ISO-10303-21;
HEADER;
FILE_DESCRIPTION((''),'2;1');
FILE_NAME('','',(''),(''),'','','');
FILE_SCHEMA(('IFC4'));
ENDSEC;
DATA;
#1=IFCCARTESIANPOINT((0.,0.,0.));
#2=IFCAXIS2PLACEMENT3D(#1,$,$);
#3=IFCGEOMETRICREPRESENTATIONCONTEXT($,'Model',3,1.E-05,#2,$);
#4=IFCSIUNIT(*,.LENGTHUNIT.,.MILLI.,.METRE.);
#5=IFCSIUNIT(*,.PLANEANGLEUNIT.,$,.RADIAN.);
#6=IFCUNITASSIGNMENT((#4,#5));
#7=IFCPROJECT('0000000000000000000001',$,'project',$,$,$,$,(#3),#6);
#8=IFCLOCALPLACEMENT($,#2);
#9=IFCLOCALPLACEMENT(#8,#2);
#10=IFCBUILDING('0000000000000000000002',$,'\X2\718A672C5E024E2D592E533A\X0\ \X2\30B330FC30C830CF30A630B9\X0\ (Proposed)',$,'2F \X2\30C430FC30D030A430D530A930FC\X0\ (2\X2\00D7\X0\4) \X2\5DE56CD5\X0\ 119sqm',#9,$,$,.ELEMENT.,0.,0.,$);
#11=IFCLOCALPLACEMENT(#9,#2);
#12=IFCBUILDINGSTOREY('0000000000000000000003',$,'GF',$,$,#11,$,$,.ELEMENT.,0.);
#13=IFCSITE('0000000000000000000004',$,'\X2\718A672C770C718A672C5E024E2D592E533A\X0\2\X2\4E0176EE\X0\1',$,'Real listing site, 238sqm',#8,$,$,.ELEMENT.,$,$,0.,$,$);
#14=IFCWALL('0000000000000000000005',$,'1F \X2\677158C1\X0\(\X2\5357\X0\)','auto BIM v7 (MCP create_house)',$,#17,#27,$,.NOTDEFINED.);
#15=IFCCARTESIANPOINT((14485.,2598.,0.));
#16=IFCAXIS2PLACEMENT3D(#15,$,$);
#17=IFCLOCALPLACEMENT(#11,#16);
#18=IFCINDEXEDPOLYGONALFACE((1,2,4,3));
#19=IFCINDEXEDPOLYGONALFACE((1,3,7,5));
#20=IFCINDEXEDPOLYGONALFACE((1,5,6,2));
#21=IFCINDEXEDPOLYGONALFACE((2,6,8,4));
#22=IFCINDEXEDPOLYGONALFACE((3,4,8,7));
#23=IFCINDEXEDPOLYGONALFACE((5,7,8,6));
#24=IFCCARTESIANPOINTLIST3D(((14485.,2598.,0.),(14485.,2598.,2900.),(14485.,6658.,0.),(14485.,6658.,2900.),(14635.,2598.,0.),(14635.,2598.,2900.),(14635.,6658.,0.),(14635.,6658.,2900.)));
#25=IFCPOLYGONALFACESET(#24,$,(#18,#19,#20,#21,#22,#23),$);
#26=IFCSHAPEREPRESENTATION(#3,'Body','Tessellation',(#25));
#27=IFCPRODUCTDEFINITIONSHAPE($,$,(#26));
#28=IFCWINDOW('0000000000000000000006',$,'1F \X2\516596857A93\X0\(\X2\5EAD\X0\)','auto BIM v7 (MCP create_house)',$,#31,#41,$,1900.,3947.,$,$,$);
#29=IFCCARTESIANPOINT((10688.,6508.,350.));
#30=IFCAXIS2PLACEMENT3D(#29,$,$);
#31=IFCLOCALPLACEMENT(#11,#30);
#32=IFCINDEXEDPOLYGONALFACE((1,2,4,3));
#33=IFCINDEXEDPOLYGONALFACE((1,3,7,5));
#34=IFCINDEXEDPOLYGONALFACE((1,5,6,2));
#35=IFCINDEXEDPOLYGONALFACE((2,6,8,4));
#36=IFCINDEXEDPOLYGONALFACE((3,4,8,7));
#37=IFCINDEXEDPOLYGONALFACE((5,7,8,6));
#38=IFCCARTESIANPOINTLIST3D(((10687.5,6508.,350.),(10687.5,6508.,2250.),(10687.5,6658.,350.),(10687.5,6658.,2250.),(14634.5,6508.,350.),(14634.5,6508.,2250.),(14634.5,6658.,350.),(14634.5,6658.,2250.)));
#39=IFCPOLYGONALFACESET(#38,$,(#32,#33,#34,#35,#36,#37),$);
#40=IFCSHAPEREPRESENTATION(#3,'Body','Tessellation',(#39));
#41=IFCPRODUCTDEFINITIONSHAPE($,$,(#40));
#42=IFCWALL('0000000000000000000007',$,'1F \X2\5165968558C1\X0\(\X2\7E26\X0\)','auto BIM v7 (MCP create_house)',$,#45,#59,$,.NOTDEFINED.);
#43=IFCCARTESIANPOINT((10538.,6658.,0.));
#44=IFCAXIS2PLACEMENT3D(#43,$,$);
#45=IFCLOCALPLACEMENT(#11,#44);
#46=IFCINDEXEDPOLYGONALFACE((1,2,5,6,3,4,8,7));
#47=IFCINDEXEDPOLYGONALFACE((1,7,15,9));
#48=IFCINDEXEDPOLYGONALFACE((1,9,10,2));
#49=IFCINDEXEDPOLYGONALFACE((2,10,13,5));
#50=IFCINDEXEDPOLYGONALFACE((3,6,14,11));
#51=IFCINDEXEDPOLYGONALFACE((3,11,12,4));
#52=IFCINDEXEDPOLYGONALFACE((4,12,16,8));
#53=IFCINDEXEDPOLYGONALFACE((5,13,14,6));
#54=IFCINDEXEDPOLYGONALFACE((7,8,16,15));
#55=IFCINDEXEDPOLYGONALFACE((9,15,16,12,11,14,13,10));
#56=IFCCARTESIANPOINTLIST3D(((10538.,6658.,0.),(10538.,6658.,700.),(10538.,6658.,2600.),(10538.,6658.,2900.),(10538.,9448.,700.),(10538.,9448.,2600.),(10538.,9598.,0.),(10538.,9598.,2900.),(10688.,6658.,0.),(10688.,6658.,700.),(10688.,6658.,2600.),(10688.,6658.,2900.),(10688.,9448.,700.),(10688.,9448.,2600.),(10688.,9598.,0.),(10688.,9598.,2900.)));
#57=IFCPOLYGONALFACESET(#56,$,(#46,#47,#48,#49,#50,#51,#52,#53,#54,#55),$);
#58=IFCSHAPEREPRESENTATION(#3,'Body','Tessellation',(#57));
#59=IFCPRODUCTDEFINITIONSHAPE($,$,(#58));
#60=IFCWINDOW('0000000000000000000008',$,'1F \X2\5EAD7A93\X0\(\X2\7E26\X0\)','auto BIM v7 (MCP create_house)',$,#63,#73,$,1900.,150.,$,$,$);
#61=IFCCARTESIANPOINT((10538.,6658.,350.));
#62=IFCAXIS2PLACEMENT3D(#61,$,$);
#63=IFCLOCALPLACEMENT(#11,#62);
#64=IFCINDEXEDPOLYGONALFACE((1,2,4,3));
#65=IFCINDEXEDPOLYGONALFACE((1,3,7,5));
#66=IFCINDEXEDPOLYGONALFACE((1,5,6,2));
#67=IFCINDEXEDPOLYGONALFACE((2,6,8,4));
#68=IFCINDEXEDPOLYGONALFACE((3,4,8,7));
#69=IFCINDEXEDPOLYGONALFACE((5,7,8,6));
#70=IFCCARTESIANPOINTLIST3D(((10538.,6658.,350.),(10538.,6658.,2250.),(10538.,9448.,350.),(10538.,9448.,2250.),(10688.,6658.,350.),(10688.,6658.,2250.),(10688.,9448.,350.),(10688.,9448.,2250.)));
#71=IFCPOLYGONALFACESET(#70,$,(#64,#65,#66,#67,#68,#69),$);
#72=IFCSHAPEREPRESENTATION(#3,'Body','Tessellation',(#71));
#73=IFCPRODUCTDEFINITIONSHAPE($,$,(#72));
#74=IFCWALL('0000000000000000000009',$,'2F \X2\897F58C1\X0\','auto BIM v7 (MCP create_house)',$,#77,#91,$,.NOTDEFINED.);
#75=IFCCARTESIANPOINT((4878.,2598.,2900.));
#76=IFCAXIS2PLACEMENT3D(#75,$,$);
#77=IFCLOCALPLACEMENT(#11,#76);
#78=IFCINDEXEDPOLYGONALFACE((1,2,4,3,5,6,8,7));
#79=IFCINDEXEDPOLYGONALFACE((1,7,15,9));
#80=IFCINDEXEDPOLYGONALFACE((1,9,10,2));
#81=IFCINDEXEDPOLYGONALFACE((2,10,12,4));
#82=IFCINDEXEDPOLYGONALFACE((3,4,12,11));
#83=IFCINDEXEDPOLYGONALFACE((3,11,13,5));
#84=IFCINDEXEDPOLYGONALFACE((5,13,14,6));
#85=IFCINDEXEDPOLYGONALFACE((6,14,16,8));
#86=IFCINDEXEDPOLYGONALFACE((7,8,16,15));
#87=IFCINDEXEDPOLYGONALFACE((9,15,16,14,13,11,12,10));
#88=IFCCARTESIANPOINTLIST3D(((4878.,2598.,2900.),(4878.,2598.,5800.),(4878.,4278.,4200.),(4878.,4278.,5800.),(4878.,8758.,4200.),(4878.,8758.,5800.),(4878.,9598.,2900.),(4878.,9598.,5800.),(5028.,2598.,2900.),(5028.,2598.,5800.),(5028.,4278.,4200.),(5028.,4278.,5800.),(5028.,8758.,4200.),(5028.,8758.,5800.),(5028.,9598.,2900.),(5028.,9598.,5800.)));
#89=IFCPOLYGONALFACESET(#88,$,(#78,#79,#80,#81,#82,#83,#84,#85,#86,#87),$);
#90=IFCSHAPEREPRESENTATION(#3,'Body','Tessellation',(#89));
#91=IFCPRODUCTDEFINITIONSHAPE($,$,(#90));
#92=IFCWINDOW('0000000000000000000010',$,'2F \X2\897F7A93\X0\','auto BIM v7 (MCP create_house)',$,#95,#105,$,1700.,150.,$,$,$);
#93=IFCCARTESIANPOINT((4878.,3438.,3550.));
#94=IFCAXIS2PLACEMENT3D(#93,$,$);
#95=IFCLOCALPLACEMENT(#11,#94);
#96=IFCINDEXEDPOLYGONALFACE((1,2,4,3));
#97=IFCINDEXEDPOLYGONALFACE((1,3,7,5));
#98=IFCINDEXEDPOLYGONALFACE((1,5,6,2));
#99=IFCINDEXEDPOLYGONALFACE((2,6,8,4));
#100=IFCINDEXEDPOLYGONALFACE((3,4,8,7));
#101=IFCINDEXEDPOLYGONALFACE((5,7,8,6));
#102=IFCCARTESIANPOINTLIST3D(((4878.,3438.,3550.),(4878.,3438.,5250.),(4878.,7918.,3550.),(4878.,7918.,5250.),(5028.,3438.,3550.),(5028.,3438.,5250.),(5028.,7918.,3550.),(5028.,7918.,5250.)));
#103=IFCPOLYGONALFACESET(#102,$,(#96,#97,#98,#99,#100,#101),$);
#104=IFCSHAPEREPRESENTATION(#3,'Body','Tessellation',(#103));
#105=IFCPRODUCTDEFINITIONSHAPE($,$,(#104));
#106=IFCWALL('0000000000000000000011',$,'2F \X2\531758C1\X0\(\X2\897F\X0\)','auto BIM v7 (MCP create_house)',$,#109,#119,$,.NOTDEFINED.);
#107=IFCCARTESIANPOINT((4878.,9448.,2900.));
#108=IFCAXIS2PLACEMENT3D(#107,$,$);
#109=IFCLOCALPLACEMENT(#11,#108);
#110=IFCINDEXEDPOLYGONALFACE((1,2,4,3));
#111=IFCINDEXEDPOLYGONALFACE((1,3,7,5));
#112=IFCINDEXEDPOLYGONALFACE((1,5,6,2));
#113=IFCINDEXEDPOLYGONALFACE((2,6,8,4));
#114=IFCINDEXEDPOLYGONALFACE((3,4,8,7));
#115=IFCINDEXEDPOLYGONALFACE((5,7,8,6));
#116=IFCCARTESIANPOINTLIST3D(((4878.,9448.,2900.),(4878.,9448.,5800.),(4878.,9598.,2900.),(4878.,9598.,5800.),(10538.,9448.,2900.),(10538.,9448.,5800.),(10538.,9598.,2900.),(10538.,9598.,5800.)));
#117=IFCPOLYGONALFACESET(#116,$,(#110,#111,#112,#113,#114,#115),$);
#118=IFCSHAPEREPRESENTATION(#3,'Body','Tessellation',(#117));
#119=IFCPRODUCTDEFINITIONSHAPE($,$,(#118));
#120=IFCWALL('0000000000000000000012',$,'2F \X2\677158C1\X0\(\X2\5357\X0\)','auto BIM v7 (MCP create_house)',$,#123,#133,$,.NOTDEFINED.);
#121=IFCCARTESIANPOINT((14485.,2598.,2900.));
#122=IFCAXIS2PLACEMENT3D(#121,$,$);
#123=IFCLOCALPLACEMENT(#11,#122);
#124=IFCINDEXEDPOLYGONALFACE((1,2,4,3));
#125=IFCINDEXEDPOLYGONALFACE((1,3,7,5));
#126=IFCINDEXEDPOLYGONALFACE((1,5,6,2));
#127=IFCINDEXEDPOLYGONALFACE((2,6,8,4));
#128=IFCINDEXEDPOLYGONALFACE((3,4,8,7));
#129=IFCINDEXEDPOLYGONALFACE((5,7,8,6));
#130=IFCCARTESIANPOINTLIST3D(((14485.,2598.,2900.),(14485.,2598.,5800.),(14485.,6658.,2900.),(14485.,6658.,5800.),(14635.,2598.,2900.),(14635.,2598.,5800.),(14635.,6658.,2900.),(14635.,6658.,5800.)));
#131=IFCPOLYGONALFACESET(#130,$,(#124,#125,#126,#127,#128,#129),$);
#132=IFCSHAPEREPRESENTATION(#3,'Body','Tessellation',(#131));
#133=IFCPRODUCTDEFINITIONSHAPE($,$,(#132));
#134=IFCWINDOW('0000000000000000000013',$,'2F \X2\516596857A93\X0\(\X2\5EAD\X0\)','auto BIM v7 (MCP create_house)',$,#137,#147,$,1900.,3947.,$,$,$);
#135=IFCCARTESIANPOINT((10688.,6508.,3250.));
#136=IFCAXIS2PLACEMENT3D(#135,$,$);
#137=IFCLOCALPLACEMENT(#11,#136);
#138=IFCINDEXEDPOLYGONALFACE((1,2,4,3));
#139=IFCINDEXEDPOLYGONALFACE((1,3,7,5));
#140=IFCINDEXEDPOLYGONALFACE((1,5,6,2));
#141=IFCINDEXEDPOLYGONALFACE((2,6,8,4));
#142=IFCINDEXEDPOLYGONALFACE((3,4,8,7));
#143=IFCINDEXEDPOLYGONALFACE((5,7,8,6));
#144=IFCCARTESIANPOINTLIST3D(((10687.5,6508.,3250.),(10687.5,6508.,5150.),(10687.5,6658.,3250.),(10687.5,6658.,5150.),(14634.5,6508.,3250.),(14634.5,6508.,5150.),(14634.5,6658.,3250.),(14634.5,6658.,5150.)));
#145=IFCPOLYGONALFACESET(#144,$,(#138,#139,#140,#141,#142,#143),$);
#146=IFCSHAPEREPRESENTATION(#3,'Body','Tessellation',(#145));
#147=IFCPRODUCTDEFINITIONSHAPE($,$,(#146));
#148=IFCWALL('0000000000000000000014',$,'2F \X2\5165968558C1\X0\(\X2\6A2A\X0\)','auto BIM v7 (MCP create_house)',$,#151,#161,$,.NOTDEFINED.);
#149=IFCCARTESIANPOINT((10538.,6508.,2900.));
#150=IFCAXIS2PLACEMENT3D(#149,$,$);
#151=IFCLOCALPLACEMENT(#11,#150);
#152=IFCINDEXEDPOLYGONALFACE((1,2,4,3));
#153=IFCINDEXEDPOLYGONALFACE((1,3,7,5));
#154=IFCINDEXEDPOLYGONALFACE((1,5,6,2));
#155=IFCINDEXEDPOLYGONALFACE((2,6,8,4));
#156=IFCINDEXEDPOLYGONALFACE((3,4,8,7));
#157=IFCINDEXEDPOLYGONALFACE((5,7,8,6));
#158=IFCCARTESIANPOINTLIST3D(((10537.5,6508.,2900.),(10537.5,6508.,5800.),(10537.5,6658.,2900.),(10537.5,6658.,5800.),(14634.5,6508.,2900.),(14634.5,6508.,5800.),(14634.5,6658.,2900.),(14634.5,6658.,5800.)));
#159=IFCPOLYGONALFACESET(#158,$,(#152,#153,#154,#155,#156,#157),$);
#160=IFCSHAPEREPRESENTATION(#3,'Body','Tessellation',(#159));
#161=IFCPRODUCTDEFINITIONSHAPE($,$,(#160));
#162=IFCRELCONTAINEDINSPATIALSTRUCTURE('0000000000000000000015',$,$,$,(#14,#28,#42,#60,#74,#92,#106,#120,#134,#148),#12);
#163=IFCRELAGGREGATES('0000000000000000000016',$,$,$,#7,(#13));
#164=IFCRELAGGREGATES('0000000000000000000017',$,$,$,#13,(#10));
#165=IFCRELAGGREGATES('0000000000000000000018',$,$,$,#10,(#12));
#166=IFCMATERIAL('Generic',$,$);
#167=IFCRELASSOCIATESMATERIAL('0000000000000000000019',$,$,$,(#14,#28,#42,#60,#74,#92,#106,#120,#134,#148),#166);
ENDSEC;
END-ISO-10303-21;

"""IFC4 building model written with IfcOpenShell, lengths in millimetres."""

from ifc_helpers import new_model, si_unit, frame, frame_2d, origin, place, context, project, spatial, rectangle, extrude, material, element, fill, save


model = new_model("IFC4")

# Units and contexts
model_context = context("Model", 3, precision=1e-05, world=origin())
ifc_project = project(units=[si_unit("LENGTHUNIT", "METRE", prefix="MILLI"), si_unit("PLANEANGLEUNIT", "RADIAN")], contexts=[model_context])

# Site, building, storey
site_placement = place(None, origin())
site = spatial("IfcSite", under=ifc_project, at=site_placement, Name="熊本県熊本市中央区2丁目1", ObjectType="Real listing site, 238sqm", CompositionType="ELEMENT", RefElevation=0.0)
building_placement = place(site_placement, origin())
building = spatial("IfcBuilding", under=site, at=building_placement, Name="熊本市中央区 コートハウス (Proposed)", ObjectType="2F ツーバイフォー (2×4) 工法 119sqm", CompositionType="ELEMENT", ElevationOfRefHeight=0.0, ElevationOfTerrain=0.0)
storey_placement = place(building_placement, origin())
storey = spatial("IfcBuildingStorey", under=building, at=storey_placement, Name="GF", CompositionType="ELEMENT", Elevation=0.0)

# Shared definitions
ifc_material = material(Name="Generic")

# Wall, opening, window
wall_1_placement = place(storey_placement, frame((14485.0, 2598.0, 0.0)))
wall_1 = element("IfcWall", 1, at=wall_1_placement, inside=storey, material=ifc_material, Name="1F 東壁(南)", Description="auto BIM v7 (MCP create_house)", PredefinedType="NOTDEFINED", context=model_context, shape_type="SweptSolid", body=[
    extrude(rectangle(XDim=150.0, YDim=4060.0, at=frame_2d((75.0, 2030.0))), frame((14485.0, 2598.0, 0.0)), (0.0, 0.0, 1.0), 2900.0),
])
opening_1_placement = place(storey_placement, frame((10688.0, 6508.0, 350.0)))
opening_1 = element("IfcOpeningElement", 2, at=opening_1_placement, cuts=wall_1, PredefinedType="NOTDEFINED", context=model_context, shape_type="SweptSolid", body=[
    extrude(rectangle(XDim=3947.0, YDim=150.0, at=frame_2d((1973.0, 75.0))), frame((10688.0, 6508.0, 350.0)), (0.0, 0.0, 1.0), 1900.0),
])
window_1_placement = place(storey_placement, frame((10688.0, 6508.0, 350.0)))
window_1 = element("IfcWindow", 3, at=window_1_placement, inside=storey, material=ifc_material, Name="1F 入隅窓(庭)", Description="auto BIM v7 (MCP create_house)", OverallHeight=1900.0, OverallWidth=3947.0, context=model_context, shape_type="SweptSolid", body=[
    extrude(rectangle(XDim=3947.0, YDim=150.0, at=frame_2d((1973.0, 75.0))), frame((10688.0, 6508.0, 350.0)), (0.0, 0.0, 1.0), 1900.0),
])
fill(opening_1, window_1)

# Wall, opening, window
wall_2_placement = place(storey_placement, frame((10538.0, 6658.0, 0.0)))
wall_2 = element("IfcWall", 4, at=wall_2_placement, inside=storey, material=ifc_material, Name="1F 入隅壁(縦)", Description="auto BIM v7 (MCP create_house)", PredefinedType="NOTDEFINED", context=model_context, shape_type="SweptSolid", body=[
    extrude(rectangle(XDim=150.0, YDim=2940.0, at=frame_2d((75.0, 1470.0))), frame((10538.0, 6658.0, 0.0)), (0.0, 0.0, 1.0), 2900.0),
])
opening_2_placement = place(storey_placement, frame((10538.0, 6658.0, 350.0)))
opening_2 = element("IfcOpeningElement", 5, at=opening_2_placement, cuts=wall_2, PredefinedType="NOTDEFINED", context=model_context, shape_type="SweptSolid", body=[
    extrude(rectangle(XDim=150.0, YDim=2790.0, at=frame_2d((75.0, 1395.0))), frame((10538.0, 6658.0, 350.0)), (0.0, 0.0, 1.0), 1900.0),
])
window_2_placement = place(storey_placement, frame((10538.0, 6658.0, 350.0)))
window_2 = element("IfcWindow", 6, at=window_2_placement, inside=storey, material=ifc_material, Name="1F 庭窓(縦)", Description="auto BIM v7 (MCP create_house)", OverallHeight=1900.0, OverallWidth=150.0, context=model_context, shape_type="SweptSolid", body=[
    extrude(rectangle(XDim=150.0, YDim=2790.0, at=frame_2d((75.0, 1395.0))), frame((10538.0, 6658.0, 350.0)), (0.0, 0.0, 1.0), 1900.0),
])
fill(opening_2, window_2)

# Wall, opening, window
wall_3_placement = place(storey_placement, frame((4878.0, 2598.0, 2900.0)))
wall_3 = element("IfcWall", 7, at=wall_3_placement, inside=storey, material=ifc_material, Name="2F 西壁", Description="auto BIM v7 (MCP create_house)", PredefinedType="NOTDEFINED", context=model_context, shape_type="SweptSolid", body=[
    extrude(rectangle(XDim=150.0, YDim=7000.0, at=frame_2d((75.0, 3500.0))), frame((4878.0, 2598.0, 2900.0)), (0.0, 0.0, 1.0), 2900.0),
])
opening_3_placement = place(storey_placement, frame((4878.0, 3438.0, 3550.0)))
opening_3 = element("IfcOpeningElement", 8, at=opening_3_placement, cuts=wall_3, PredefinedType="NOTDEFINED", context=model_context, shape_type="SweptSolid", body=[
    extrude(rectangle(XDim=150.0, YDim=4480.0, at=frame_2d((75.0, 2240.0))), frame((4878.0, 3438.0, 3550.0)), (0.0, 0.0, 1.0), 1700.0),
])
window_3_placement = place(storey_placement, frame((4878.0, 3438.0, 3550.0)))
window_3 = element("IfcWindow", 9, at=window_3_placement, inside=storey, material=ifc_material, Name="2F 西窓", Description="auto BIM v7 (MCP create_house)", OverallHeight=1700.0, OverallWidth=150.0, context=model_context, shape_type="SweptSolid", body=[
    extrude(rectangle(XDim=150.0, YDim=4480.0, at=frame_2d((75.0, 2240.0))), frame((4878.0, 3438.0, 3550.0)), (0.0, 0.0, 1.0), 1700.0),
])
fill(opening_3, window_3)

# Wall
wall_4_placement = place(storey_placement, frame((4878.0, 9448.0, 2900.0)))
element("IfcWall", 10, at=wall_4_placement, inside=storey, material=ifc_material, Name="2F 北壁(西)", Description="auto BIM v7 (MCP create_house)", PredefinedType="NOTDEFINED", context=model_context, shape_type="SweptSolid", body=[
    extrude(rectangle(XDim=5660.0, YDim=150.0, at=frame_2d((2830.0, 75.0))), frame((4878.0, 9448.0, 2900.0)), (0.0, 0.0, 1.0), 2900.0),
])

# Wall, opening, window
wall_5_placement = place(storey_placement, frame((14485.0, 2598.0, 2900.0)))
wall_5 = element("IfcWall", 11, at=wall_5_placement, inside=storey, material=ifc_material, Name="2F 東壁(南)", Description="auto BIM v7 (MCP create_house)", PredefinedType="NOTDEFINED", context=model_context, shape_type="SweptSolid", body=[
    extrude(rectangle(XDim=150.0, YDim=4060.0, at=frame_2d((75.0, 2030.0))), frame((14485.0, 2598.0, 2900.0)), (0.0, 0.0, 1.0), 2900.0),
])
opening_4_placement = place(storey_placement, frame((10688.0, 6508.0, 3250.0)))
opening_4 = element("IfcOpeningElement", 12, at=opening_4_placement, cuts=wall_5, PredefinedType="NOTDEFINED", context=model_context, shape_type="SweptSolid", body=[
    extrude(rectangle(XDim=3947.0, YDim=150.0, at=frame_2d((1973.0, 75.0))), frame((10688.0, 6508.0, 3250.0)), (0.0, 0.0, 1.0), 1900.0),
])
window_4_placement = place(storey_placement, frame((10688.0, 6508.0, 3250.0)))
window_4 = element("IfcWindow", 13, at=window_4_placement, inside=storey, material=ifc_material, Name="2F 入隅窓(庭)", Description="auto BIM v7 (MCP create_house)", OverallHeight=1900.0, OverallWidth=3947.0, context=model_context, shape_type="SweptSolid", body=[
    extrude(rectangle(XDim=3947.0, YDim=150.0, at=frame_2d((1973.0, 75.0))), frame((10688.0, 6508.0, 3250.0)), (0.0, 0.0, 1.0), 1900.0),
])
fill(opening_4, window_4)

# Wall
wall_6_placement = place(storey_placement, frame((10538.0, 6508.0, 2900.0)))
element("IfcWall", 14, at=wall_6_placement, inside=storey, material=ifc_material, Name="2F 入隅壁(横)", Description="auto BIM v7 (MCP create_house)", PredefinedType="NOTDEFINED", context=model_context, shape_type="SweptSolid", body=[
    extrude(rectangle(XDim=4097.0, YDim=150.0, at=frame_2d((2048.0, 75.0))), frame((10538.0, 6508.0, 2900.0)), (0.0, 0.0, 1.0), 2900.0),
])

save(model, "model.ifc")
